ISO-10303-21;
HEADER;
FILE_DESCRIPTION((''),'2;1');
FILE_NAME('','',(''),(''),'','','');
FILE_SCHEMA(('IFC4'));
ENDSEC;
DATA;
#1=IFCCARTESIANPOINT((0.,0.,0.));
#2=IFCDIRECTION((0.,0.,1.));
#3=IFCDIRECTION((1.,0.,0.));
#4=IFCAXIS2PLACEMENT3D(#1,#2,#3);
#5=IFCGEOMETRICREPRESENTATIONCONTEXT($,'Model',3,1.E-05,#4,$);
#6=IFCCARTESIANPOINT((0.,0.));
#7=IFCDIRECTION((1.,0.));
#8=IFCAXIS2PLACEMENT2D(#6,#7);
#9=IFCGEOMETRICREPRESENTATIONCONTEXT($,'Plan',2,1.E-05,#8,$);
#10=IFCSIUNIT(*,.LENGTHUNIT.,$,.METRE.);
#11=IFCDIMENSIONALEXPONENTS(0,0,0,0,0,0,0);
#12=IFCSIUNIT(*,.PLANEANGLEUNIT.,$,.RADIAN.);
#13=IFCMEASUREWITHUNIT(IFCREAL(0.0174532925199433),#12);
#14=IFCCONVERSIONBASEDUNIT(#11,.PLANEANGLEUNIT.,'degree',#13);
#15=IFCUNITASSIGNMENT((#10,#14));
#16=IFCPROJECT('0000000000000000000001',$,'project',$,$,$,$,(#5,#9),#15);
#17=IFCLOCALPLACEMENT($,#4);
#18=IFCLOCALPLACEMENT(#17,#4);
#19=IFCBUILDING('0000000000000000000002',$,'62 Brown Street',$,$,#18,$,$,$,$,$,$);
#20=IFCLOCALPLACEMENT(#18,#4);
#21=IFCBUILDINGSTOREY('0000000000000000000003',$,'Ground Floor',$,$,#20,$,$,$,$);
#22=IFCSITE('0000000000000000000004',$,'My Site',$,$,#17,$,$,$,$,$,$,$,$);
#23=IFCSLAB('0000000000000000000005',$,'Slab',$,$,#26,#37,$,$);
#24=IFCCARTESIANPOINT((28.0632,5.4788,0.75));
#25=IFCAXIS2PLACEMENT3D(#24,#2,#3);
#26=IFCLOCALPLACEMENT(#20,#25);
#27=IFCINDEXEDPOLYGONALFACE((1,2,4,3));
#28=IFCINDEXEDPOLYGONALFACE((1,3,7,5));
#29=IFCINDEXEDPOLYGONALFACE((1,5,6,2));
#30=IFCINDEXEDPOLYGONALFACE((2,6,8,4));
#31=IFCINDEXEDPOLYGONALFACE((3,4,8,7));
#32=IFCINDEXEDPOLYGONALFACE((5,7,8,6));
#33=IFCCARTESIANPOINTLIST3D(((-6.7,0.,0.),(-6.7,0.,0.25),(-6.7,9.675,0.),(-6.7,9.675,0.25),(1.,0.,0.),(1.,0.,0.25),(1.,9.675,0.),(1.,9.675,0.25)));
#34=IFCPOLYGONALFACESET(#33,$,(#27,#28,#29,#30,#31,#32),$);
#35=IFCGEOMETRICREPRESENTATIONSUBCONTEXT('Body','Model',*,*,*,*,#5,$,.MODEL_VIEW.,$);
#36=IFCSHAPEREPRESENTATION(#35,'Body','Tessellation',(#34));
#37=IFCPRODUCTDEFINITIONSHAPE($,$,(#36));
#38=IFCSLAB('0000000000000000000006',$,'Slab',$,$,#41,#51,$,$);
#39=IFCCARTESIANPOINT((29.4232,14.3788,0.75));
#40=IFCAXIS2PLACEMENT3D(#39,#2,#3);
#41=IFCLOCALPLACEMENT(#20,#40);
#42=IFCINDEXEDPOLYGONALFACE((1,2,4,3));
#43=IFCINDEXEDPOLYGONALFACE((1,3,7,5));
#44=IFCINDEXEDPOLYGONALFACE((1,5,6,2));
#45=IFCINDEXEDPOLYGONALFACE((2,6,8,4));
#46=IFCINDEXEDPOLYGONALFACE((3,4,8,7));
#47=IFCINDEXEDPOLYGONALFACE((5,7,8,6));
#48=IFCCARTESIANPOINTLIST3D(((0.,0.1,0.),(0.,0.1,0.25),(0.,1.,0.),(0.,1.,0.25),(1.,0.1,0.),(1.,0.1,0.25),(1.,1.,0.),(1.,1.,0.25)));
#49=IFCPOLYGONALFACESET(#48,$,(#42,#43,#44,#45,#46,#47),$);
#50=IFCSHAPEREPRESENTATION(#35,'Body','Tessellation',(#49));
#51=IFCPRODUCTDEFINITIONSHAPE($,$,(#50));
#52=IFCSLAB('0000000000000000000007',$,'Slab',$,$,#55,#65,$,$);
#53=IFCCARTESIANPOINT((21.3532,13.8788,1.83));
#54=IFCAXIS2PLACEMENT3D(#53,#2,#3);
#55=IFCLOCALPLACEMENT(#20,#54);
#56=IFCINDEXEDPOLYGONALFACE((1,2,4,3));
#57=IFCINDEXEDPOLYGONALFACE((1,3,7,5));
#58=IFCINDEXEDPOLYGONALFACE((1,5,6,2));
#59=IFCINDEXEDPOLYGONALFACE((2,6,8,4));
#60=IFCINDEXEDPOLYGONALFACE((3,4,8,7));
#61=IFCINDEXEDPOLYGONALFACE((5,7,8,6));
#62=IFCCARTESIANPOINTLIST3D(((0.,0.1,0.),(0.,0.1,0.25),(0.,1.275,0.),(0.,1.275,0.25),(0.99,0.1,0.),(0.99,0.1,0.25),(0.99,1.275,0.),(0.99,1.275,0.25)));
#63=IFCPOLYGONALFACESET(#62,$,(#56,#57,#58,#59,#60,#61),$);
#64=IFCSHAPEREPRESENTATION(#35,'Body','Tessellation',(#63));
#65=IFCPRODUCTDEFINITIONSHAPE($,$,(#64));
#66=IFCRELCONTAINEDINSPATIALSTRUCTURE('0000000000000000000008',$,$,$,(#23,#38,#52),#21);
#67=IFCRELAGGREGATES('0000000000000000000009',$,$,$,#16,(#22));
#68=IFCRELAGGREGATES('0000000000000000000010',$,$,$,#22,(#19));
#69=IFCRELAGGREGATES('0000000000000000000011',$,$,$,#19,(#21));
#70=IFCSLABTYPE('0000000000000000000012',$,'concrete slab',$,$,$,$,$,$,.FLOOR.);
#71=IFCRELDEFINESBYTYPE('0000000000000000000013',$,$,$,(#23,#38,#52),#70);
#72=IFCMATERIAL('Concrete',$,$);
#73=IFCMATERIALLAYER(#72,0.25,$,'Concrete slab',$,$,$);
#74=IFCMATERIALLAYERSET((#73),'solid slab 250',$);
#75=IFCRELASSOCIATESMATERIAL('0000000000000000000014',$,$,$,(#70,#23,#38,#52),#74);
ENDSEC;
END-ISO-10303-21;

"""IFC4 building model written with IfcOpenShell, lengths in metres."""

from ifc_helpers import new_model, entity, si_unit, converted_unit, frame, origin_with_axes, origin_2d_with_axis, place, context, subcontext, project, spatial, line, indexed_curve, outline, extrude, material, layer, layer_set, layer_usage, type_object, element, save


model = new_model("IFC4")

# Units and contexts
model_context = context("Model", 3, precision=1e-05, world=origin_with_axes())
plan_context = context("Plan", 2, precision=1e-05, world=origin_2d_with_axis())
body_context = subcontext(model_context, "Body", "Model", "MODEL_VIEW")
ifc_project = project(units=[si_unit("LENGTHUNIT", "METRE"), converted_unit("PLANEANGLEUNIT", "degree", entity("IfcReal", 0.0174532925199433), si_unit("PLANEANGLEUNIT", "RADIAN"), dimensions=[0, 0, 0, 0, 0, 0, 0])], contexts=[model_context, plan_context])

# Site, building, storey
site_placement = place(None, origin_with_axes())
site = spatial("IfcSite", under=ifc_project, at=site_placement, Name="My Site")
building_placement = place(site_placement, origin_with_axes())
building = spatial("IfcBuilding", under=site, at=building_placement, Name="62 Brown Street")
storey_placement = place(building_placement, origin_with_axes())
storey = spatial("IfcBuildingStorey", under=building, at=storey_placement, Name="Ground Floor")

# Shared definitions
ifc_material_1 = material(Name="Concrete")

# Slabs
ifc_layer_1 = layer(ifc_material_1, 0.25, Name="Concrete slab")
ifc_layer_set_1 = layer_set([ifc_layer_1], Name="solid slab 250")
slab_type = type_object("IfcSlabType", Name="concrete slab", PredefinedType="FLOOR", material=ifc_layer_set_1)
ifc_layer_usage_1 = layer_usage(ifc_layer_set_1, "AXIS3", "POSITIVE", 0.0)
slab_1_placement = place(storey_placement, frame((28.0632, 5.4788, 0.75), z_axis=(0.0, 0.0, 1.0), x_axis=(1.0, 0.0, 0.0)))
element("IfcSlab", 1, at=slab_1_placement, inside=storey, type_object=slab_type, material=ifc_layer_usage_1, Name="Slab", context=body_context, shape_type="SweptSolid", body=[
    extrude(outline(indexed_curve([(1.0, 9.675), (-6.7, 9.675), (-6.7, 0.0), (1.0, 0.0)], segments=[line(3, 2), line(2, 1), line(1, 4), line(4, 3)], self_intersect=False)), None, (0.0, 0.0, 1.0), 0.25),
])
ifc_layer_usage_2 = layer_usage(ifc_layer_set_1, "AXIS3", "POSITIVE", 0.0)
slab_2_placement = place(storey_placement, frame((29.4232, 14.3788, 0.75), z_axis=(0.0, 0.0, 1.0), x_axis=(1.0, 0.0, 0.0)))
element("IfcSlab", 2, at=slab_2_placement, inside=storey, type_object=slab_type, material=ifc_layer_usage_2, Name="Slab", context=body_context, shape_type="SweptSolid", body=[
    extrude(outline(indexed_curve([(1.0, 1.0), (1.0, 0.1), (0.0, 0.1), (0.0, 1.0)], segments=[line(3, 2), line(2, 1), line(1, 4), line(4, 3)], self_intersect=False)), None, (0.0, 0.0, 1.0), 0.25),
])
ifc_layer_usage_3 = layer_usage(ifc_layer_set_1, "AXIS3", "POSITIVE", 0.0)
slab_3_placement = place(storey_placement, frame((21.3532, 13.8788, 1.83), z_axis=(0.0, 0.0, 1.0), x_axis=(1.0, 0.0, 0.0)))
element("IfcSlab", 3, at=slab_3_placement, inside=storey, type_object=slab_type, material=ifc_layer_usage_3, Name="Slab", context=body_context, shape_type="SweptSolid", body=[
    extrude(outline(indexed_curve([(0.99, 1.275), (0.99, 0.1), (0.0, 0.1), (0.0, 1.275)], segments=[line(3, 2), line(2, 1), line(1, 4), line(4, 3)], self_intersect=False)), None, (0.0, 0.0, 1.0), 0.25),
])

save(model, "model.ifc")
